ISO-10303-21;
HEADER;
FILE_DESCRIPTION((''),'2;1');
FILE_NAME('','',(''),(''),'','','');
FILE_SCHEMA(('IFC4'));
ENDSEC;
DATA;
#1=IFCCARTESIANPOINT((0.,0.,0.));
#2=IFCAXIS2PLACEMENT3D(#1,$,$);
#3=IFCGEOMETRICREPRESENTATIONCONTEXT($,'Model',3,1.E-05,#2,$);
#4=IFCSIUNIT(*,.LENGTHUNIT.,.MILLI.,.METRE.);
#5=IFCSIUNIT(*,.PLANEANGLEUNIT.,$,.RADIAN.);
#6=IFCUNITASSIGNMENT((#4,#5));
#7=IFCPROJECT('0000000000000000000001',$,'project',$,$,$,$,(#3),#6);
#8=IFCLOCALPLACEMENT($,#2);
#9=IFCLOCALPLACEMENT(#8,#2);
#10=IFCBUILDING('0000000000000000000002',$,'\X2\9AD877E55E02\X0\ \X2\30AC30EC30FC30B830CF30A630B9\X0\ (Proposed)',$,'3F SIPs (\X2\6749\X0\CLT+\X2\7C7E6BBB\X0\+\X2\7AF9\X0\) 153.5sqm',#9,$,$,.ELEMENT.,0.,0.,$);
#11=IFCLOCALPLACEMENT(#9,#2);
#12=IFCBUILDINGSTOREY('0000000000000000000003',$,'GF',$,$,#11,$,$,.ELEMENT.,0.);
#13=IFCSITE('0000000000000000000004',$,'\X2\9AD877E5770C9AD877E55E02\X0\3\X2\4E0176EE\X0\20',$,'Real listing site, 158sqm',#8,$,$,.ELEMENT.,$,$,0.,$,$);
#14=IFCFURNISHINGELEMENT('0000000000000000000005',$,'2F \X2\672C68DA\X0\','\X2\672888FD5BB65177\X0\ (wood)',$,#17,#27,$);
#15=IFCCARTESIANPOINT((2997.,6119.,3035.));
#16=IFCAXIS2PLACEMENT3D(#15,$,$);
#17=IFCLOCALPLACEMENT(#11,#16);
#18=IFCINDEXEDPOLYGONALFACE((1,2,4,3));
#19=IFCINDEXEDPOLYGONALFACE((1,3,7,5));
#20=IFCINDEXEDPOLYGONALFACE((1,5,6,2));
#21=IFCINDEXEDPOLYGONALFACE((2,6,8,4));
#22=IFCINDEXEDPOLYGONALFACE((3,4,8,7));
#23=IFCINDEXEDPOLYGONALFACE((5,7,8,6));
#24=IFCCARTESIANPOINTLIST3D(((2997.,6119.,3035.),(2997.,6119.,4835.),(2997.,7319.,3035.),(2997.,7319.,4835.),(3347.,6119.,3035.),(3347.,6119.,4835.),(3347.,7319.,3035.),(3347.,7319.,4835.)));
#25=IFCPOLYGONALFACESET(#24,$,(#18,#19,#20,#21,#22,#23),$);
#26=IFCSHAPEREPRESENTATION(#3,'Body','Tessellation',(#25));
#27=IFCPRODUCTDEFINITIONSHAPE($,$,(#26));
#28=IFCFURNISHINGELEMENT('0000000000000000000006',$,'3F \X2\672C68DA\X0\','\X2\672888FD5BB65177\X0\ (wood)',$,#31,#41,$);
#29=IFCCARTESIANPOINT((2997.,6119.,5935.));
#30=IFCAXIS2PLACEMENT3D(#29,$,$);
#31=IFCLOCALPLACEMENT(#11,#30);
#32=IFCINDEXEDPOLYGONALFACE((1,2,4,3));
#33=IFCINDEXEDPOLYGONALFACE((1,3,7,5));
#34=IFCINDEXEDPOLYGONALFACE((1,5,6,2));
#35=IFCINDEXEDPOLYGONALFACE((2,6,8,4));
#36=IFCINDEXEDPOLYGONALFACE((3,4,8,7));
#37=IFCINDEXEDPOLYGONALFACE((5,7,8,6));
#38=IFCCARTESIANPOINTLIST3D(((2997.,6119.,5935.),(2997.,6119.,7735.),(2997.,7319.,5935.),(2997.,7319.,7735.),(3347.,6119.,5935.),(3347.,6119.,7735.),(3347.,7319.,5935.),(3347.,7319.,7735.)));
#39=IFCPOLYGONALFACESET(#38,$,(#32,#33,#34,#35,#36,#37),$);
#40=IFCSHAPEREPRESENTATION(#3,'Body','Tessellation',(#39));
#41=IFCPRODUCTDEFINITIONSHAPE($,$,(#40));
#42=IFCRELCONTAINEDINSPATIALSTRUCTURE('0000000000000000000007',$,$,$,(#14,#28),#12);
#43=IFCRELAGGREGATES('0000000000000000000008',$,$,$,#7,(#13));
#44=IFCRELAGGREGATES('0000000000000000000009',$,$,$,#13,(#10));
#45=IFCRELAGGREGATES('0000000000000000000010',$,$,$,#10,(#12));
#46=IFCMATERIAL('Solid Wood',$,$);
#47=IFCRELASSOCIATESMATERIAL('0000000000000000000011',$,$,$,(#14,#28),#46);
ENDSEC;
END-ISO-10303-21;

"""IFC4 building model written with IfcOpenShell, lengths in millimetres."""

from ifc_helpers import new_model, si_unit, frame, frame_2d, origin, place, context, project, spatial, rectangle, extrude, material, element, save


model = new_model("IFC4")

# Units and contexts
model_context = context("Model", 3, precision=1e-05, world=origin())
ifc_project = project(units=[si_unit("LENGTHUNIT", "METRE", prefix="MILLI"), si_unit("PLANEANGLEUNIT", "RADIAN")], contexts=[model_context])

# Site, building, storey
site_placement = place(None, origin())
site = spatial("IfcSite", under=ifc_project, at=site_placement, Name="高知県高知市3丁目20", ObjectType="Real listing site, 158sqm", CompositionType="ELEMENT", RefElevation=0.0)
building_placement = place(site_placement, origin())
building = spatial("IfcBuilding", under=site, at=building_placement, Name="高知市 ガレージハウス (Proposed)", ObjectType="3F SIPs (杉CLT+籾殻+竹) 153.5sqm", CompositionType="ELEMENT", ElevationOfRefHeight=0.0, ElevationOfTerrain=0.0)
storey_placement = place(building_placement, origin())
storey = spatial("IfcBuildingStorey", under=building, at=storey_placement, Name="GF", CompositionType="ELEMENT", Elevation=0.0)

# Shared definitions
ifc_material_1 = material(Name="Solid Wood")

# Furnishing elements
furnishing_1_placement = place(storey_placement, frame((2997.0, 6119.0, 3035.0)))
element("IfcFurnishingElement", 1, at=furnishing_1_placement, inside=storey, material=ifc_material_1, Name="2F 本棚", Description="木製家具 (wood)", context=model_context, shape_type="SweptSolid", body=[
    extrude(rectangle(XDim=350.0, YDim=1200.0, at=frame_2d((175.0, 600.0))), frame((2997.0, 6119.0, 3035.0)), (0.0, 0.0, 1.0), 1800.0),
])
furnishing_2_placement = place(storey_placement, frame((2997.0, 6119.0, 5935.0)))
element("IfcFurnishingElement", 2, at=furnishing_2_placement, inside=storey, material=ifc_material_1, Name="3F 本棚", Description="木製家具 (wood)", context=model_context, shape_type="SweptSolid", body=[
    extrude(rectangle(XDim=350.0, YDim=1200.0, at=frame_2d((175.0, 600.0))), frame((2997.0, 6119.0, 5935.0)), (0.0, 0.0, 1.0), 1800.0),
])

save(model, "model.ifc")
